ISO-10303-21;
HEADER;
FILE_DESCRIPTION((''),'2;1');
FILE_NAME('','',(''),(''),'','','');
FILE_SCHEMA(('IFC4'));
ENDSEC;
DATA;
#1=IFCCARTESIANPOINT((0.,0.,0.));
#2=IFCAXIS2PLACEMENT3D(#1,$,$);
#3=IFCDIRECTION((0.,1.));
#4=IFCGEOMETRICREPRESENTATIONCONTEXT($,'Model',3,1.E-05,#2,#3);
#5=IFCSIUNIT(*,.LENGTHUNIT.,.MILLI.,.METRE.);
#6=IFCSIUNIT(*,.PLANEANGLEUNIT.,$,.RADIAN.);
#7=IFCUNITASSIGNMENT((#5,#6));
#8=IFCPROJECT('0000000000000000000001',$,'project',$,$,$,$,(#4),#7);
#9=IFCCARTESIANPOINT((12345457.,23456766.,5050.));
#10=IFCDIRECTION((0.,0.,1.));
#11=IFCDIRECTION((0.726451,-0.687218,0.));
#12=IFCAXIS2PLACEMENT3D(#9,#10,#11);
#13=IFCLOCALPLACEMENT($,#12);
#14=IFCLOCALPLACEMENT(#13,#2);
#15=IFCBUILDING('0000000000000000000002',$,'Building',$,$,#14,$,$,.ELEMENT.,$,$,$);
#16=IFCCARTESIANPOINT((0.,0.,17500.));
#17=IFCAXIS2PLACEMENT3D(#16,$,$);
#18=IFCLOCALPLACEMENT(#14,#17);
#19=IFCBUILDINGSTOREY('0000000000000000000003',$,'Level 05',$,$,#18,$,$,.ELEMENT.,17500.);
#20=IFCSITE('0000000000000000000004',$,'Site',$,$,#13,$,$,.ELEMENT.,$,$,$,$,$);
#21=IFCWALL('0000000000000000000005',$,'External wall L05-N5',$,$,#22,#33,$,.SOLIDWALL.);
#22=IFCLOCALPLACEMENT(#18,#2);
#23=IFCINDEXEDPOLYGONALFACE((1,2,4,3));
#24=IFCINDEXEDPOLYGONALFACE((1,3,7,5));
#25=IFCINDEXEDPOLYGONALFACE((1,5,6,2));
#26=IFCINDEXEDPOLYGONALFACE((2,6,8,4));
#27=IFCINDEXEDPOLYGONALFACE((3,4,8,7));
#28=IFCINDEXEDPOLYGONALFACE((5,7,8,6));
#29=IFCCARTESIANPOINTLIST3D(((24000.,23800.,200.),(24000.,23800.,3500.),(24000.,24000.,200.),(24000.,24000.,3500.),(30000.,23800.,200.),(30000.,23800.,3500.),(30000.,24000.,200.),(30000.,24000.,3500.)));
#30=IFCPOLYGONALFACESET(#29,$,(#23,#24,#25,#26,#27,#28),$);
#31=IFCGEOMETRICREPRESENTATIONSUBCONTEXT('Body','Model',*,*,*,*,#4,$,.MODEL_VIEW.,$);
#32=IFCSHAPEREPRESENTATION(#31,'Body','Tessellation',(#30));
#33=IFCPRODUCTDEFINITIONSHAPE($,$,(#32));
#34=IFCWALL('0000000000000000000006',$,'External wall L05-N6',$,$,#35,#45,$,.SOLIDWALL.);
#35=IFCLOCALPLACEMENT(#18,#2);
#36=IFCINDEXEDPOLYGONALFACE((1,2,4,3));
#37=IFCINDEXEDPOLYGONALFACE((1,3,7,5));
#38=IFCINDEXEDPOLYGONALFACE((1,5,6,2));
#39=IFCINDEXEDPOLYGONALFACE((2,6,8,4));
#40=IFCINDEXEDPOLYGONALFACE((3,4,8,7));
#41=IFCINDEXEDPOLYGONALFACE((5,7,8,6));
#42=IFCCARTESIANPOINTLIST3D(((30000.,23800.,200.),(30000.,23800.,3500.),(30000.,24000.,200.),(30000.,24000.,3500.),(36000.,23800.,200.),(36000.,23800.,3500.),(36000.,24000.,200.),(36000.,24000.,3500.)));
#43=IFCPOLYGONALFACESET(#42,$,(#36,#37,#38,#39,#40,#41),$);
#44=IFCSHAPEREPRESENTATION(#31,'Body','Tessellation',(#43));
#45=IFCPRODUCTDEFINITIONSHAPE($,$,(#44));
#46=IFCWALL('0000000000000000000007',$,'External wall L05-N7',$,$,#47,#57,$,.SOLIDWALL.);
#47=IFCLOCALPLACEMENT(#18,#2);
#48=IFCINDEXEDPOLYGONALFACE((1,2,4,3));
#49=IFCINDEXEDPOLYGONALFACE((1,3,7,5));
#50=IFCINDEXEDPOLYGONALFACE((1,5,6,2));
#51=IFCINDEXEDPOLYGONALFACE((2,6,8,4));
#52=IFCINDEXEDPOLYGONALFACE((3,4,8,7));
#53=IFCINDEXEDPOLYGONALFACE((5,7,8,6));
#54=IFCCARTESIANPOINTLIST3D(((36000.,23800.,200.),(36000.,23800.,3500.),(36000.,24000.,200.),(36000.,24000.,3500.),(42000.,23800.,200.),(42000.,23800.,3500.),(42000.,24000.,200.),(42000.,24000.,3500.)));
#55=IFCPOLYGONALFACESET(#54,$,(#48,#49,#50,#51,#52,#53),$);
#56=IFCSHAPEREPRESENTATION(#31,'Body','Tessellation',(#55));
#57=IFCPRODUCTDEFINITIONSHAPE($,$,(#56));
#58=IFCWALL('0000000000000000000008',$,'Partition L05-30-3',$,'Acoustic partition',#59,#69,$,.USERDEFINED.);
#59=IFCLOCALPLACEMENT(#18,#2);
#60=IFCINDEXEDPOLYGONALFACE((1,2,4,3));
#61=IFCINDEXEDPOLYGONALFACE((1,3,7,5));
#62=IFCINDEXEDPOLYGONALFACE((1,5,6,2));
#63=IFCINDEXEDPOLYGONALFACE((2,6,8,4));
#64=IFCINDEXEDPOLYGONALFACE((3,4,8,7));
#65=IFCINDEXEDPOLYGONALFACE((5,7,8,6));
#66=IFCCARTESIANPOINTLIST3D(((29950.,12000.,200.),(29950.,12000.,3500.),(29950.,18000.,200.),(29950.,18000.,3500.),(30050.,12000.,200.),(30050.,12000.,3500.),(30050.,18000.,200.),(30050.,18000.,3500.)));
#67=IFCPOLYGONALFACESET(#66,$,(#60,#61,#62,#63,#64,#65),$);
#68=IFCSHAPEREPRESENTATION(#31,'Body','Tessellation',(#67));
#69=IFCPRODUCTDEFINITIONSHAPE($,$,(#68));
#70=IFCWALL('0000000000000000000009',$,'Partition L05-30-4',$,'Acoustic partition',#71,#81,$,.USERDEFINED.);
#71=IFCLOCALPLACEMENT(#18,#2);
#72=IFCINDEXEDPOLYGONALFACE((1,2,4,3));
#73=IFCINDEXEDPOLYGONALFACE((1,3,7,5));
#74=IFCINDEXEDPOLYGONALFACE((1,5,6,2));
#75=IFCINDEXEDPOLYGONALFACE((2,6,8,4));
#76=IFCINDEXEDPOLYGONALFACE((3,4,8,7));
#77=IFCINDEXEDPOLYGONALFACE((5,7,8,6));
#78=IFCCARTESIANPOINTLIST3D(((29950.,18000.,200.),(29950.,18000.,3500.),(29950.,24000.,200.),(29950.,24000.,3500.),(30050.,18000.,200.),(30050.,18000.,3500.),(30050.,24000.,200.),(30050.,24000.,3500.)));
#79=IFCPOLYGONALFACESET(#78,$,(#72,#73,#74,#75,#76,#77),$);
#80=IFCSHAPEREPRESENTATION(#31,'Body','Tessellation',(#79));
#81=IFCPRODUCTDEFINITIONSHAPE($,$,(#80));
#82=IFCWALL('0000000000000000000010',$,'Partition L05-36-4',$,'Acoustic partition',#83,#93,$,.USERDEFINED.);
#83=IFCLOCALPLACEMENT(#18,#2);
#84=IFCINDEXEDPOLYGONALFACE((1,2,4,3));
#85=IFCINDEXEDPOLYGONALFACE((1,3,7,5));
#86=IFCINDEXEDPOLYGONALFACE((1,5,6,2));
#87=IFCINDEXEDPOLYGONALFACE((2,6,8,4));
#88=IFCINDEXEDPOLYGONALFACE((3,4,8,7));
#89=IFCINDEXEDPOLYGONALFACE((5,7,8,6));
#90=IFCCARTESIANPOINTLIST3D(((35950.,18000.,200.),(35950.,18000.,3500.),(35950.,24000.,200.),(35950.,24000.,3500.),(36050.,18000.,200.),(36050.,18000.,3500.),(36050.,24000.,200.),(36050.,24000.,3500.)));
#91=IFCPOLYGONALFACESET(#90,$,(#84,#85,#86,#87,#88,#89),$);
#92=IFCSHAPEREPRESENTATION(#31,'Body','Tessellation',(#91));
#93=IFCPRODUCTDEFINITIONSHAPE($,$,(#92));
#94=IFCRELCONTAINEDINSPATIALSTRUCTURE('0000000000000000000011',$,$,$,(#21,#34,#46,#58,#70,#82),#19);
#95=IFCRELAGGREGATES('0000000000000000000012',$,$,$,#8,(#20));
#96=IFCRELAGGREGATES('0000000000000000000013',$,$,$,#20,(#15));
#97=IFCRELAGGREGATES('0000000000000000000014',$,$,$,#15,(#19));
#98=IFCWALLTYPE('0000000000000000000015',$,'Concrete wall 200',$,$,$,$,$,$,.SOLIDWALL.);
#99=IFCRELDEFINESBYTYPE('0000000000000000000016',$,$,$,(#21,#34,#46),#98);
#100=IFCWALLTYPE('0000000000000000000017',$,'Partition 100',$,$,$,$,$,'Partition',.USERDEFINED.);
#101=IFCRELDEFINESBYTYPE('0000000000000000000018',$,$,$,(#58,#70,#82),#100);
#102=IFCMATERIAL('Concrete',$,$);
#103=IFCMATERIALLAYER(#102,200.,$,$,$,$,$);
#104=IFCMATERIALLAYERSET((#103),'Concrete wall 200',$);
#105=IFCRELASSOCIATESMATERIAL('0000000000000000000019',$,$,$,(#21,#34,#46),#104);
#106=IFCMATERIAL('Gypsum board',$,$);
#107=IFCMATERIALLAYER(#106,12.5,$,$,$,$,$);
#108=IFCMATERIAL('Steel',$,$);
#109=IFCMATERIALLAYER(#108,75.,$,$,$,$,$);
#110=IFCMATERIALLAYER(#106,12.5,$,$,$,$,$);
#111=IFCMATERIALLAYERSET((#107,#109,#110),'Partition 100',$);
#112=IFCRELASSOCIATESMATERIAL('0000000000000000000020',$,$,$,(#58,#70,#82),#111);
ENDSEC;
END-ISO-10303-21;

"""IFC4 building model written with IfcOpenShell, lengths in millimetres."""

from ifc_helpers import new_model, si_unit, direction, frame, origin, place, context, subcontext, project, spatial, rectangle, extrude, material, layer, layer_set, layer_usage, type_object, element, save


model = new_model("IFC4")

# Units and contexts
model_context = context("Model", 3, precision=1e-05, world=origin(), true_north=direction((0.0, 1.0)))
body_context = subcontext(model_context, "Body", "Model", "MODEL_VIEW")
ifc_project = project(units=[si_unit("LENGTHUNIT", "METRE", prefix="MILLI"), si_unit("PLANEANGLEUNIT", "RADIAN")], contexts=[model_context])

# Site, building, storey
site_placement = place(None, frame((12345457.0, 23456766.0, 5050.0), z_axis=(0.0, 0.0, 1.0), x_axis=(0.726451, -0.687218, 0.0)))
site = spatial("IfcSite", under=ifc_project, at=site_placement, Name="Site", CompositionType="ELEMENT")
building_placement = place(site_placement, origin())
building = spatial("IfcBuilding", under=site, at=building_placement, Name="Building", CompositionType="ELEMENT")
storey_placement = place(building_placement, frame((0.0, 0.0, 17500.0)))
storey = spatial("IfcBuildingStorey", under=building, at=storey_placement, Name="Level 05", CompositionType="ELEMENT", Elevation=17500.0)

# Shared definitions
ifc_material_1 = material(Name="Steel")

# Shared definitions
ifc_material_2 = material(Name="Concrete")

# Walls
ifc_layer_1 = layer(ifc_material_2, 200.0)
ifc_layer_set_1 = layer_set([ifc_layer_1], Name="Concrete wall 200")
ifc_layer_usage_1 = layer_usage(ifc_layer_set_1, "AXIS2", "POSITIVE", 0.0)
wall_type_1 = type_object("IfcWallType", Name="Concrete wall 200", PredefinedType="SOLIDWALL")
for number, where, name in (
    (1, (24000.0, 23800.0, 200.0), "External wall L05-N5"),
    (2, (30000.0, 23800.0, 200.0), "External wall L05-N6"),
    (3, (36000.0, 23800.0, 200.0), "External wall L05-N7"),
):
    element("IfcWall", number, at=place(storey_placement, frame(where)), inside=storey, type_object=wall_type_1, material=ifc_layer_usage_1, Name=name, PredefinedType="SOLIDWALL", context=body_context, shape_type="SweptSolid", body=[
        extrude(rectangle(XDim=6000.0, YDim=200.0), frame((3000.0, 100.0, 0.0)), (0.0, 0.0, 1.0), 3300.0),
    ])
ifc_material_3 = material(Name="Gypsum board")
ifc_layer_2 = layer(ifc_material_3, 12.5)
ifc_layer_3 = layer(ifc_material_1, 75.0)
ifc_layer_4 = layer(ifc_material_3, 12.5)
ifc_layer_set_2 = layer_set([ifc_layer_2, ifc_layer_3, ifc_layer_4], Name="Partition 100")
ifc_layer_usage_2 = layer_usage(ifc_layer_set_2, "AXIS2", "POSITIVE", 0.0)
wall_type_2 = type_object("IfcWallType", Name="Partition 100", ElementType="Partition", PredefinedType="USERDEFINED")
for number, where, name in (
    (4, (29950.0, 12000.0, 200.0), "Partition L05-30-3"),
    (5, (29950.0, 18000.0, 200.0), "Partition L05-30-4"),
    (6, (35950.0, 18000.0, 200.0), "Partition L05-36-4"),
):
    element("IfcWall", number, at=place(storey_placement, frame(where)), inside=storey, type_object=wall_type_2, material=ifc_layer_usage_2, Name=name, ObjectType="Acoustic partition", PredefinedType="USERDEFINED", context=body_context, shape_type="SweptSolid", body=[
        extrude(rectangle(XDim=100.0, YDim=6000.0), frame((50.0, 3000.0, 0.0)), (0.0, 0.0, 1.0), 3300.0),
    ])

save(model, "model.ifc")
